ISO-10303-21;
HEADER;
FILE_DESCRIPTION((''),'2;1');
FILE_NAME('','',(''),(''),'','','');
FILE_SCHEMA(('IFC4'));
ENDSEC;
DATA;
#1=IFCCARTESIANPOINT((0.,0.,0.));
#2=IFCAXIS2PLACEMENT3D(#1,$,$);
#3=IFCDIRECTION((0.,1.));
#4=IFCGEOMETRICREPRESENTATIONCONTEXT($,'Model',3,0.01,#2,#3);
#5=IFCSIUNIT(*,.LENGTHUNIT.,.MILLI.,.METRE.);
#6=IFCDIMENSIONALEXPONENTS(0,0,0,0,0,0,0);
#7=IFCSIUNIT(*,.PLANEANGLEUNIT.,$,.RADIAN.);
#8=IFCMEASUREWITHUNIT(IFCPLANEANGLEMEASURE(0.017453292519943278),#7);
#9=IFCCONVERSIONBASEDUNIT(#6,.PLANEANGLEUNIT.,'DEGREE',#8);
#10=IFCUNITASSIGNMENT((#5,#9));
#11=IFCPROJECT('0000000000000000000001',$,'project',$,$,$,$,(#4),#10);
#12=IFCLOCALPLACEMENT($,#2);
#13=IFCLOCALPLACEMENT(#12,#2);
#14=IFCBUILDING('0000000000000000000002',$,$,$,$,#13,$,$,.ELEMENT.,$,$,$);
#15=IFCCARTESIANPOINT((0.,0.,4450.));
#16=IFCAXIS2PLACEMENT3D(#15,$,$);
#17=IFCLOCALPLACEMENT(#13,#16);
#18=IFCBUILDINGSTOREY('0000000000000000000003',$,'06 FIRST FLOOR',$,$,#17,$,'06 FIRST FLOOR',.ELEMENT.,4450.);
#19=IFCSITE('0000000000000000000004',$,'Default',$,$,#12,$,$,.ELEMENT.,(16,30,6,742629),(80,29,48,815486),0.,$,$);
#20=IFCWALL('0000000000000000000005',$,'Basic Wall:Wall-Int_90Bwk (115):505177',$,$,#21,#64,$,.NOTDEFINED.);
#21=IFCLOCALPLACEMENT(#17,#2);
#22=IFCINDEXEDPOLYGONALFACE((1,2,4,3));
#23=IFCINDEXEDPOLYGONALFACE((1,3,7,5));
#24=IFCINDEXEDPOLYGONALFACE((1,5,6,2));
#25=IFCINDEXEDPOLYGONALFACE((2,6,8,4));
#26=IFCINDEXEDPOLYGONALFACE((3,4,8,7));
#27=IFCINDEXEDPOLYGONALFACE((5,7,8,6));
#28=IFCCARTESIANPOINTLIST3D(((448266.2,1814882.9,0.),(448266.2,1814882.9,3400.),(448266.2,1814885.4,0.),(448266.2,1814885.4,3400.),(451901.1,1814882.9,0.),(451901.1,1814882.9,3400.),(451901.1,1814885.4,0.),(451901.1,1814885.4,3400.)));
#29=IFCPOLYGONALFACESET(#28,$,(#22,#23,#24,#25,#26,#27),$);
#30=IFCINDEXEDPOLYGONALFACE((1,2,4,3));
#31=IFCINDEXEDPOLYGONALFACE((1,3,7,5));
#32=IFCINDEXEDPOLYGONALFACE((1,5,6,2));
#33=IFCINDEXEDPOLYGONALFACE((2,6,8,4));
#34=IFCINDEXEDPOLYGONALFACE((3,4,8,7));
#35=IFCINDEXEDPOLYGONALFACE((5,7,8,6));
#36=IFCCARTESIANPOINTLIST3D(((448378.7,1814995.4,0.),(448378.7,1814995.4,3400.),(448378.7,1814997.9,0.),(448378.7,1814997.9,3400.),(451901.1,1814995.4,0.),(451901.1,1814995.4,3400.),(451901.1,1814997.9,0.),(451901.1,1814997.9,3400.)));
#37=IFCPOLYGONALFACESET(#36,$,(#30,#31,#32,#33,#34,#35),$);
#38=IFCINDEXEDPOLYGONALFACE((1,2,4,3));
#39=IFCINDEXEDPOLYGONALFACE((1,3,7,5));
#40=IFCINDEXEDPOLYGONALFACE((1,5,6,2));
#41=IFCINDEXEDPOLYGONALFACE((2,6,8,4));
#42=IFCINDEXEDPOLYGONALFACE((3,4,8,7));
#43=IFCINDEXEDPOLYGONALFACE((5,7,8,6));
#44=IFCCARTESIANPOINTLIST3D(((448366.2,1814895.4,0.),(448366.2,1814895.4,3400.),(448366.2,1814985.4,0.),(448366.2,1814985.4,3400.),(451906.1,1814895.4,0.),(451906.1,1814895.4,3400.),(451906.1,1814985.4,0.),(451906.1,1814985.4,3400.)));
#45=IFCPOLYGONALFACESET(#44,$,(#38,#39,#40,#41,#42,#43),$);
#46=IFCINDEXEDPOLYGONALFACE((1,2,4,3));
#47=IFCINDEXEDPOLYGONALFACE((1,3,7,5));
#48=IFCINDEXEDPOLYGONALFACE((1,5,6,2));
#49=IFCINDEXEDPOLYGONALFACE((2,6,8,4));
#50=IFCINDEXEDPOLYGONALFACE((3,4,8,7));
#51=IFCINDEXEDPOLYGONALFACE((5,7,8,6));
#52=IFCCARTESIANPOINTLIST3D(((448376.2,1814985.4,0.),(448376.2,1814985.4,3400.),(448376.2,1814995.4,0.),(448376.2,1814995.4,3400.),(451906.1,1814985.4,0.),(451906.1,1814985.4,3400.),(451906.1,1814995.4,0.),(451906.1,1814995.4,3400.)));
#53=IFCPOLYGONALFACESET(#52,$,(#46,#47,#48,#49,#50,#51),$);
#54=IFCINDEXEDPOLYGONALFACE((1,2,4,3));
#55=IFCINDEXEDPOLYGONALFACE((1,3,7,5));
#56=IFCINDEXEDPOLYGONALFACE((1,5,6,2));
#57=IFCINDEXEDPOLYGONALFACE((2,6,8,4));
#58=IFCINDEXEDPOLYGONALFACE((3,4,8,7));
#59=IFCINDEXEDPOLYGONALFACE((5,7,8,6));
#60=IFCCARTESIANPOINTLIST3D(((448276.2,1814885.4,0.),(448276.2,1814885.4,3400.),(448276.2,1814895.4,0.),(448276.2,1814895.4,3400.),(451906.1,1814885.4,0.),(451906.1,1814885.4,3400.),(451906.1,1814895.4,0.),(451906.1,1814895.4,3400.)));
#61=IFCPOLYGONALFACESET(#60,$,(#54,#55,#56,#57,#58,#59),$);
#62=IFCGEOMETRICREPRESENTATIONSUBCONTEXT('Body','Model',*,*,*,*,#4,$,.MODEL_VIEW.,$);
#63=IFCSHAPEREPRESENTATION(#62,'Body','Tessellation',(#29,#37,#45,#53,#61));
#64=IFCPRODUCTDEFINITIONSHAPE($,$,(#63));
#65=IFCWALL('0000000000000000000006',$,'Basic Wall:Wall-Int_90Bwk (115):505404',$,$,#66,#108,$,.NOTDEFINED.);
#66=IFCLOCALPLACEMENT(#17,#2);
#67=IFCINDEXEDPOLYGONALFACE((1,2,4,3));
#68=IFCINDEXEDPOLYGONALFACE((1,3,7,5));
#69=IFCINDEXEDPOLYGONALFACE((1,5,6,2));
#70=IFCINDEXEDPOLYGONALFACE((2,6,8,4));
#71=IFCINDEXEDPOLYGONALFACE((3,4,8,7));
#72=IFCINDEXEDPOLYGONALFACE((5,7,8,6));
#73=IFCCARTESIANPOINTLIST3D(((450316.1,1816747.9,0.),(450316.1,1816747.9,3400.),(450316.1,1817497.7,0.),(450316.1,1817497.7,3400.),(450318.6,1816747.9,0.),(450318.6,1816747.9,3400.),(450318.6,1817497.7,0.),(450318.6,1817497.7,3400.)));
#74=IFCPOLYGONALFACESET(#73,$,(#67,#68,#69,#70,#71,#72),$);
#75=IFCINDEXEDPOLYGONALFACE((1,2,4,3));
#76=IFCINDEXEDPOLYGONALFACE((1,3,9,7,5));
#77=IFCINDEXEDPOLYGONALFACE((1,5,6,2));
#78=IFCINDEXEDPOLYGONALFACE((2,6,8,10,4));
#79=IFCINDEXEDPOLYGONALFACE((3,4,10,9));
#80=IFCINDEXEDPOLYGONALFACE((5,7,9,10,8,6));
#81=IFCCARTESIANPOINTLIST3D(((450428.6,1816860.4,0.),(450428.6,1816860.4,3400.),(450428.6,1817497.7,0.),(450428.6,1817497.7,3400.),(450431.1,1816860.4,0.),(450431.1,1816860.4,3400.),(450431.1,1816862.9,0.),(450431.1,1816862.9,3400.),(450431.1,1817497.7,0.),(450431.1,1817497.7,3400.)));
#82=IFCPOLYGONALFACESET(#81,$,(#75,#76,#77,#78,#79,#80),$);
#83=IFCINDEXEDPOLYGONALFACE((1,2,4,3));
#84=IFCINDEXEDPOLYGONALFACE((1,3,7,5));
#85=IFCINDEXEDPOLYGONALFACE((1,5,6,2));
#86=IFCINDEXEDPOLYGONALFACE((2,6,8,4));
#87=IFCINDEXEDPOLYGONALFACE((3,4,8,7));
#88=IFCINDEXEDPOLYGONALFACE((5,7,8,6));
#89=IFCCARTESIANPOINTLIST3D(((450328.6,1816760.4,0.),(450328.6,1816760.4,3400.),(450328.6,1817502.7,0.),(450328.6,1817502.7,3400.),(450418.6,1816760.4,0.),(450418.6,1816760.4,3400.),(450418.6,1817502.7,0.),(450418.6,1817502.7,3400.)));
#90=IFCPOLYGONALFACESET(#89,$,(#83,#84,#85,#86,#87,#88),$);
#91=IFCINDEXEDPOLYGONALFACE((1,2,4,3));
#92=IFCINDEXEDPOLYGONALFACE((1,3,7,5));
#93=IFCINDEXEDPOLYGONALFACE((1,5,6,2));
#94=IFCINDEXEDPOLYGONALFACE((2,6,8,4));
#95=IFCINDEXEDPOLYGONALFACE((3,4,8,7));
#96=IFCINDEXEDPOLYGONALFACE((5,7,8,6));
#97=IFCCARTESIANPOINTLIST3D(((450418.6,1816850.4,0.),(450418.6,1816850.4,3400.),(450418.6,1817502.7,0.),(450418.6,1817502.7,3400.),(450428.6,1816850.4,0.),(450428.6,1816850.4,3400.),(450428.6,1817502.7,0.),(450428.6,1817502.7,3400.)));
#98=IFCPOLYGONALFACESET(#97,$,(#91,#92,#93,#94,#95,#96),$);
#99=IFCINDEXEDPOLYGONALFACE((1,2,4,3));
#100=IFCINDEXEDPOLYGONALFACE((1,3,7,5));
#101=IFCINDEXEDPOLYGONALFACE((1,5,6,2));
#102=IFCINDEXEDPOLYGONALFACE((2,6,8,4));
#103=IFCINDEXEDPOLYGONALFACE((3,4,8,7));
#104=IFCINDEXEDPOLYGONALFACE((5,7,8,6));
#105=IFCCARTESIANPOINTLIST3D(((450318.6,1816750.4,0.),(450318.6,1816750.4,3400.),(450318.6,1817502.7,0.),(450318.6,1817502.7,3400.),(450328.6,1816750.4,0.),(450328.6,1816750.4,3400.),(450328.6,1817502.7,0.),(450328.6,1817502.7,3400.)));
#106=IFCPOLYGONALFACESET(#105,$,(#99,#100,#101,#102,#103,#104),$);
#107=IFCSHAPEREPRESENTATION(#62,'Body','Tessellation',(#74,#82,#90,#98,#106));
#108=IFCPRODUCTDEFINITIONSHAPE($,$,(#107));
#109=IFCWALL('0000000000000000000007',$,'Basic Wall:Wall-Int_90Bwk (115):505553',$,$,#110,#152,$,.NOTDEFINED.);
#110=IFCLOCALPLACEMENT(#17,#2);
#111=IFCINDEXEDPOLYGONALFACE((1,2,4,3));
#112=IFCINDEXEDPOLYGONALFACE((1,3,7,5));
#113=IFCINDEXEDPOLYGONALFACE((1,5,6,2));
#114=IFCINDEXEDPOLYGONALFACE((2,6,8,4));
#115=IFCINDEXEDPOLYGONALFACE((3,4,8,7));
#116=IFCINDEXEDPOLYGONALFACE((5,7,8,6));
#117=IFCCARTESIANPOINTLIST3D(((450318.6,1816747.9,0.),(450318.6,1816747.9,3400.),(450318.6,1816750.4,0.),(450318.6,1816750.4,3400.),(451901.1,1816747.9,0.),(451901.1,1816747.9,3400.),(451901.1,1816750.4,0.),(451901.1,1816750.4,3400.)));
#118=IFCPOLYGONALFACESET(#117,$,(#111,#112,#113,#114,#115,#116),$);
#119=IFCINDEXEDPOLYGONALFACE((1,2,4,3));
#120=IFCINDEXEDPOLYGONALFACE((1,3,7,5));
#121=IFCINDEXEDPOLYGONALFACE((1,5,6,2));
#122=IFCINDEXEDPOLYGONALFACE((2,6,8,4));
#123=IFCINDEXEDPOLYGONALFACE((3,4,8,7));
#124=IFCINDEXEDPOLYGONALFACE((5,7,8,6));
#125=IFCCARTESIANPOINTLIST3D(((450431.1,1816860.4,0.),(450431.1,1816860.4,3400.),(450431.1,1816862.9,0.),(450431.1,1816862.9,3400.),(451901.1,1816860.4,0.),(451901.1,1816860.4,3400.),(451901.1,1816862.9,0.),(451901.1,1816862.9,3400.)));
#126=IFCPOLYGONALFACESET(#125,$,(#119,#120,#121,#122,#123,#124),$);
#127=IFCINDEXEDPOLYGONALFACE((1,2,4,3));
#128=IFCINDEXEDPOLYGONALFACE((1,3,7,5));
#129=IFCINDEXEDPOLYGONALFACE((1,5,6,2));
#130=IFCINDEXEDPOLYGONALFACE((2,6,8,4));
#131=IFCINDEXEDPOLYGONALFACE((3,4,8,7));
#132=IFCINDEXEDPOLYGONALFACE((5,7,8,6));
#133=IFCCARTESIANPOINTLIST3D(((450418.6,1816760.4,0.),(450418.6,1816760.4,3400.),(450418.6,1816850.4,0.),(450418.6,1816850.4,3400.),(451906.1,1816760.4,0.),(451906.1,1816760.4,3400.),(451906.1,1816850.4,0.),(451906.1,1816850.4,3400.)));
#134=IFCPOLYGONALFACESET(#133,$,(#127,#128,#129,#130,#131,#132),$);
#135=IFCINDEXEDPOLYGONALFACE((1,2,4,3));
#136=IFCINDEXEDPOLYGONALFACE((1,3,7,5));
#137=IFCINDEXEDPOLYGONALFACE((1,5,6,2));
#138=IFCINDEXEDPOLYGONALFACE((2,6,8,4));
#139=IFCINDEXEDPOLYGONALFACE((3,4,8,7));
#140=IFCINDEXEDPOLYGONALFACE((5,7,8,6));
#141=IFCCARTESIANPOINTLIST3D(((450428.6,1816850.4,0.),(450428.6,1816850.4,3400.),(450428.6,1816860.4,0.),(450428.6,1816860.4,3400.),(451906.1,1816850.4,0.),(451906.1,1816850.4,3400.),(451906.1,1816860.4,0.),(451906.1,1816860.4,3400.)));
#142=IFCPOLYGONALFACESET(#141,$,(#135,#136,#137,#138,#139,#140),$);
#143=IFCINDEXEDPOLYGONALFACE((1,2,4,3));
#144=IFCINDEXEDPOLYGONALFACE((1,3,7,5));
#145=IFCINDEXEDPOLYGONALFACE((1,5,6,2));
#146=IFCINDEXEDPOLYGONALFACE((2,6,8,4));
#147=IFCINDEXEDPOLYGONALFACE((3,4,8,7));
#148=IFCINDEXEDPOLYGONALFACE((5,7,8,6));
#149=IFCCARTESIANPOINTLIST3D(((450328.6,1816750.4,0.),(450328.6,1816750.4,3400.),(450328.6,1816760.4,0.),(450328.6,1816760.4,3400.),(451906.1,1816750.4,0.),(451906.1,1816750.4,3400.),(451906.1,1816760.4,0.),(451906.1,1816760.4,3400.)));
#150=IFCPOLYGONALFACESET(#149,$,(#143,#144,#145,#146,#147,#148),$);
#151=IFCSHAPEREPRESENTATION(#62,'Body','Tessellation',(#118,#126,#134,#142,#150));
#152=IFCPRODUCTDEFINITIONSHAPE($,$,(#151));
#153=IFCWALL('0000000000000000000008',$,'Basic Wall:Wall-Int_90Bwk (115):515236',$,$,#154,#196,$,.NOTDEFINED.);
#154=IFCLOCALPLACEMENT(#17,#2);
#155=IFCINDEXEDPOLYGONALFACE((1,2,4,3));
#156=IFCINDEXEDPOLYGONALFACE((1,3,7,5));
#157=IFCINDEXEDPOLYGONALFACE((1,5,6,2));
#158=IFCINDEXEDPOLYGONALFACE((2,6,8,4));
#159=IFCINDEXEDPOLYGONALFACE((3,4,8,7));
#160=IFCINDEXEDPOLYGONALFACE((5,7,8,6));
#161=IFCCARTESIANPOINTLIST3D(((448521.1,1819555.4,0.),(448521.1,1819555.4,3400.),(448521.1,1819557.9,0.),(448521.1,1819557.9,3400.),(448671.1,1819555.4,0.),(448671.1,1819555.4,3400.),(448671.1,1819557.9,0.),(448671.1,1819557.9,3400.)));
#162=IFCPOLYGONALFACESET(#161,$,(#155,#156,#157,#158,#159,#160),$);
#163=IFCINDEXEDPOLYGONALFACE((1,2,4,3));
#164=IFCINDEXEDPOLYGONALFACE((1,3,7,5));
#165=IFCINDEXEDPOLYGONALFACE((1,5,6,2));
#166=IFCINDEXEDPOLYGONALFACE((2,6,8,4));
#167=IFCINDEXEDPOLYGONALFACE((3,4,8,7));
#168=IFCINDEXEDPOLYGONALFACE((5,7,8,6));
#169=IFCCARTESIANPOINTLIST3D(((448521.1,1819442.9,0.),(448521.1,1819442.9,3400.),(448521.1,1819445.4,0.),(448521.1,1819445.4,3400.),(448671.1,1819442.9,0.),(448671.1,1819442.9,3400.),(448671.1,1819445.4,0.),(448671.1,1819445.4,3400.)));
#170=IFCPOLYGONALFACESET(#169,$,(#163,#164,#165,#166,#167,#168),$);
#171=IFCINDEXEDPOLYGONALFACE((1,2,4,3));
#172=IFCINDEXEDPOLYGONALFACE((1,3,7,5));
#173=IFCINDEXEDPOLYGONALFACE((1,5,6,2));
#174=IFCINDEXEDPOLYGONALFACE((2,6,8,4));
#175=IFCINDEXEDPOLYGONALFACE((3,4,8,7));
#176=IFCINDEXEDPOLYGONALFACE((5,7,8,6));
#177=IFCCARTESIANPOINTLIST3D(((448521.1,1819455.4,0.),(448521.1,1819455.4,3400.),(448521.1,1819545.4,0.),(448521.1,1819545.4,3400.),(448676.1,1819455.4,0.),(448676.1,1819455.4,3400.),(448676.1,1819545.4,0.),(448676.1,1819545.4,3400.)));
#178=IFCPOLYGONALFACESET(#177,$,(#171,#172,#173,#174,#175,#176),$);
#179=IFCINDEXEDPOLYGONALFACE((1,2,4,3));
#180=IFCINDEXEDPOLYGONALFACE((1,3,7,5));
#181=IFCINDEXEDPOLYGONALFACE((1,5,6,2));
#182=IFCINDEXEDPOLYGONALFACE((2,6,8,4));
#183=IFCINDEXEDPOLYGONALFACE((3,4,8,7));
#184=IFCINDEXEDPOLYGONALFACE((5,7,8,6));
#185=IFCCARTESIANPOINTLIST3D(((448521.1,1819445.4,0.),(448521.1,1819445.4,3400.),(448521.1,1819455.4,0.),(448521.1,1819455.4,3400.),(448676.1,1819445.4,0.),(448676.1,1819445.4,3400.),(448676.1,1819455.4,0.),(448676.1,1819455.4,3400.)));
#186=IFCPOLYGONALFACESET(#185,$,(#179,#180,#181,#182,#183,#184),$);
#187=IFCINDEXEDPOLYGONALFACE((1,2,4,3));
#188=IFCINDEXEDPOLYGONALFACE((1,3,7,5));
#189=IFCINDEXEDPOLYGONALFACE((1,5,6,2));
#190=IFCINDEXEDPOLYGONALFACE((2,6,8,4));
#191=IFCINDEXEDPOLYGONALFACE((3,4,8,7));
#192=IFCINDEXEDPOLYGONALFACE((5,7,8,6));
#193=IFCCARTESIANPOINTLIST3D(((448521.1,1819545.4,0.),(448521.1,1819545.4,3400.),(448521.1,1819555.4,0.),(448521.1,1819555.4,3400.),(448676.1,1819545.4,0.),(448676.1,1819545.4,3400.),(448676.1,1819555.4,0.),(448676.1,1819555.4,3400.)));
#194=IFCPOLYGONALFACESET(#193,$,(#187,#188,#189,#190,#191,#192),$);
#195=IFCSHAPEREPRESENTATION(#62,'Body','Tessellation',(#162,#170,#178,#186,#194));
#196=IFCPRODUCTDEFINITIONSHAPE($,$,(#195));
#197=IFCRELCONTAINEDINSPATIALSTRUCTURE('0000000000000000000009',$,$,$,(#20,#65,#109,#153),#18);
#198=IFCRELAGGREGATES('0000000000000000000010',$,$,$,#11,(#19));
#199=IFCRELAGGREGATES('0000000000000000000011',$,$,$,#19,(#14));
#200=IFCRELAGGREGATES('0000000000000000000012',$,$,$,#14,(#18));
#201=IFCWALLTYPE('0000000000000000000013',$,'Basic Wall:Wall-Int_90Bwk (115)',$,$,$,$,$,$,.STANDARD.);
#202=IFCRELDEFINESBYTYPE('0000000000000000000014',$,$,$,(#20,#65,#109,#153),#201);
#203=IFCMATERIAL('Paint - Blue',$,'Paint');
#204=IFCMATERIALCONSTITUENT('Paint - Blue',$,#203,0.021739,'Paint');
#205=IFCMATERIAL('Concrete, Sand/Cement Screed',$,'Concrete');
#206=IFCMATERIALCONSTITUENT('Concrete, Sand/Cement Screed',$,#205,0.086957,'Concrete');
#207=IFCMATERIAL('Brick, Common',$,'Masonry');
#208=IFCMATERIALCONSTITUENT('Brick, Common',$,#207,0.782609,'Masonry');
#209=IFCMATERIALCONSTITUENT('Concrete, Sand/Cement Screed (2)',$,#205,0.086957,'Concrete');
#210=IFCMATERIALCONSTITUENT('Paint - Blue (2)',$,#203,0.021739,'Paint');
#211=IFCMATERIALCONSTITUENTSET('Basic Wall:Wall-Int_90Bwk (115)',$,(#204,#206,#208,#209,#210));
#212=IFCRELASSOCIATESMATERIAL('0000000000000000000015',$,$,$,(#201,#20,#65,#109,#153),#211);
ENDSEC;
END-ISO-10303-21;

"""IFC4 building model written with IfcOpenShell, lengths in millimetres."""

from ifc_helpers import new_model, entity, si_unit, converted_unit, direction, frame, origin, place, context, subcontext, project, spatial, indexed_curve, outline, extrude, material, constituent, constituent_set, type_object, element, save


model = new_model("IFC4")

# Units and contexts
model_context = context("Model", 3, precision=0.01, world=origin(), true_north=direction((0.0, 1.0)))
body_context = subcontext(model_context, "Body", "Model", "MODEL_VIEW")
ifc_project = project(units=[si_unit("LENGTHUNIT", "METRE", prefix="MILLI"), converted_unit("PLANEANGLEUNIT", "DEGREE", entity("IfcPlaneAngleMeasure", 0.017453292519943278), si_unit("PLANEANGLEUNIT", "RADIAN"), dimensions=[0, 0, 0, 0, 0, 0, 0])], contexts=[model_context])

# Site, building, storey
site_placement = place(None, origin())
site = spatial("IfcSite", under=ifc_project, at=site_placement, Name="Default", CompositionType="ELEMENT", RefLatitude=(16, 30, 6, 742629), RefLongitude=(80, 29, 48, 815486), RefElevation=0.0)
building_placement = place(site_placement, origin())
building = spatial("IfcBuilding", under=site, at=building_placement, CompositionType="ELEMENT")
storey_placement = place(building_placement, frame((0.0, 0.0, 4450.0)))
storey = spatial("IfcBuildingStorey", under=building, at=storey_placement, Name="06 FIRST FLOOR", LongName="06 FIRST FLOOR", CompositionType="ELEMENT", Elevation=4450.0)

# Shared definitions
ifc_material_1 = material(Name="Paint - Blue", Category="Paint")
ifc_constituent_1 = constituent(ifc_material_1, Name="Paint - Blue", Category="Paint", fraction=0.021739)
ifc_material_2 = material(Name="Concrete, Sand/Cement Screed", Category="Concrete")
ifc_constituent_2 = constituent(ifc_material_2, Name="Concrete, Sand/Cement Screed", Category="Concrete", fraction=0.086957)
ifc_material_3 = material(Name="Brick, Common", Category="Masonry")
ifc_constituent_3 = constituent(ifc_material_3, Name="Brick, Common", Category="Masonry", fraction=0.782609)
ifc_constituent_4 = constituent(ifc_material_2, Name="Concrete, Sand/Cement Screed (2)", Category="Concrete", fraction=0.086957)
ifc_constituent_5 = constituent(ifc_material_1, Name="Paint - Blue (2)", Category="Paint", fraction=0.021739)
ifc_constituent_set_1 = constituent_set(constituents=[ifc_constituent_1, ifc_constituent_2, ifc_constituent_3, ifc_constituent_4, ifc_constituent_5], Name="Basic Wall:Wall-Int_90Bwk (115)")
wall_type_1 = type_object("IfcWallType", Name="Basic Wall:Wall-Int_90Bwk (115)", PredefinedType="STANDARD", material=ifc_constituent_set_1)

# Walls
wall_1_placement = place(storey_placement, frame((448378.7, 1814940.4, 0.0)))
element("IfcWall", 1, at=wall_1_placement, inside=storey, type_object=wall_type_1, material=ifc_constituent_set_1, Name="Basic Wall:Wall-Int_90Bwk (115):505177", PredefinedType="NOTDEFINED", context=body_context, shape_type="SweptSolid", body=[
    extrude(outline(indexed_curve([(-1.2, -1817.5), (1.3, -1817.5), (1.3, 1817.5), (-1.2, 1817.5), (-1.2, -1817.5)], self_intersect=False)), frame((1705.0, -56.3, 0.0), z_axis=(0.0, 0.0, 1.0), x_axis=(0.0, 1.0, 0.0)), (0.0, 0.0, 1.0), 3400.0),
    extrude(outline(indexed_curve([(-1.2, -1761.2), (1.3, -1761.2), (1.3, 1761.2), (-1.2, 1761.2), (-1.2, -1761.2)], self_intersect=False)), frame((1761.2, 56.3, 0.0), z_axis=(0.0, 0.0, 1.0), x_axis=(0.0, -1.0, 0.0)), (0.0, 0.0, 1.0), 3400.0),
    extrude(outline(indexed_curve([(-1770.0, -45.0), (1770.0, -45.0), (1770.0, 45.0), (-1770.0, 45.0), (-1770.0, -45.0)], self_intersect=False)), frame((1757.5, 0.0, 0.0)), (0.0, 0.0, 1.0), 3400.0),
    extrude(outline(indexed_curve([(-1765.0, -5.0), (1765.0, -5.0), (1765.0, 5.0), (-1765.0, 5.0), (-1765.0, -5.0)], self_intersect=False)), frame((1762.5, 50.0, 0.0)), (0.0, 0.0, 1.0), 3400.0),
    extrude(outline(indexed_curve([(-1815.0, -5.0), (1815.0, -5.0), (1815.0, 5.0), (-1815.0, 5.0), (-1815.0, -5.0)], self_intersect=False)), frame((1712.5, -50.0, 0.0)), (0.0, 0.0, 1.0), 3400.0),
])
wall_2_placement = place(storey_placement, frame((450373.6, 1817497.7, 0.0), z_axis=(0.0, 0.0, 1.0), x_axis=(0.0, -1.0, 0.0)))
element("IfcWall", 2, at=wall_2_placement, inside=storey, type_object=wall_type_1, material=ifc_constituent_set_1, Name="Basic Wall:Wall-Int_90Bwk (115):505404", PredefinedType="NOTDEFINED", context=body_context, shape_type="SweptSolid", body=[
    extrude(outline(indexed_curve([(-1.3, -374.9), (1.2, -374.9), (1.2, 374.9), (-1.3, 374.9), (-1.3, -374.9)], self_intersect=False)), frame((374.9, -56.2, 0.0), z_axis=(0.0, 0.0, 1.0), x_axis=(0.0, 1.0, 0.0)), (0.0, 0.0, 1.0), 3400.0),
    extrude(outline(indexed_curve([(-252.9, -1.0), (381.9, -1.0), (381.9, 1.5), (-255.4, 1.5), (-255.4, -1.0), (-252.9, -1.0)], self_intersect=False)), frame((381.9, 56.5, 0.0), z_axis=(0.0, 0.0, 1.0), x_axis=(-1.0, 0.0, 0.0)), (0.0, 0.0, 1.0), 3400.0),
    extrude(outline(indexed_curve([(-371.2, -45.0), (371.2, -45.0), (371.2, 45.0), (-371.2, 45.0), (-371.2, -45.0)], self_intersect=False)), frame((366.2, 0.0, 0.0)), (0.0, 0.0, 1.0), 3400.0),
    extrude(outline(indexed_curve([(-326.2, -5.0), (326.2, -5.0), (326.2, 5.0), (-326.2, 5.0), (-326.2, -5.0)], self_intersect=False)), frame((321.2, 50.0, 0.0)), (0.0, 0.0, 1.0), 3400.0),
    extrude(outline(indexed_curve([(-376.2, -5.0), (376.2, -5.0), (376.2, 5.0), (-376.2, 5.0), (-376.2, -5.0)], self_intersect=False)), frame((371.2, -50.0, 0.0)), (0.0, 0.0, 1.0), 3400.0),
])
wall_3_placement = place(storey_placement, frame((450431.1, 1816805.4, 0.0)))
element("IfcWall", 3, at=wall_3_placement, inside=storey, type_object=wall_type_1, material=ifc_constituent_set_1, Name="Basic Wall:Wall-Int_90Bwk (115):505553", PredefinedType="NOTDEFINED", context=body_context, shape_type="SweptSolid", body=[
    extrude(outline(indexed_curve([(-1.2, -791.3), (1.3, -791.3), (1.3, 791.3), (-1.2, 791.3), (-1.2, -791.3)], self_intersect=False)), frame((678.8, -56.3, 0.0), z_axis=(0.0, 0.0, 1.0), x_axis=(0.0, 1.0, 0.0)), (0.0, 0.0, 1.0), 3400.0),
    extrude(outline(indexed_curve([(-1.2, -735.0), (1.3, -735.0), (1.3, 735.0), (-1.2, 735.0), (-1.2, -735.0)], self_intersect=False)), frame((735.0, 56.3, 0.0), z_axis=(0.0, 0.0, 1.0), x_axis=(0.0, -1.0, 0.0)), (0.0, 0.0, 1.0), 3400.0),
    extrude(outline(indexed_curve([(-743.8, -45.0), (743.8, -45.0), (743.8, 45.0), (-743.8, 45.0), (-743.8, -45.0)], self_intersect=False)), frame((731.3, 0.0, 0.0)), (0.0, 0.0, 1.0), 3400.0),
    extrude(outline(indexed_curve([(-738.8, -5.0), (738.8, -5.0), (738.8, 5.0), (-738.8, 5.0), (-738.8, -5.0)], self_intersect=False)), frame((736.3, 50.0, 0.0)), (0.0, 0.0, 1.0), 3400.0),
    extrude(outline(indexed_curve([(-788.8, -5.0), (788.8, -5.0), (788.8, 5.0), (-788.8, 5.0), (-788.8, -5.0)], self_intersect=False)), frame((686.3, -50.0, 0.0)), (0.0, 0.0, 1.0), 3400.0),
])
wall_4_placement = place(storey_placement, frame((448671.1, 1819500.4, 0.0), z_axis=(0.0, 0.0, 1.0), x_axis=(-1.0, 0.0, 0.0)))
element("IfcWall", 4, at=wall_4_placement, inside=storey, type_object=wall_type_1, material=ifc_constituent_set_1, Name="Basic Wall:Wall-Int_90Bwk (115):515236", PredefinedType="NOTDEFINED", context=body_context, shape_type="SweptSolid", body=[
    extrude(outline(indexed_curve([(-1.2, -75.0), (1.3, -75.0), (1.3, 75.0), (-1.2, 75.0), (-1.2, -75.0)], self_intersect=False)), frame((75.0, -56.3, 0.0), z_axis=(0.0, 0.0, 1.0), x_axis=(0.0, 1.0, 0.0)), (0.0, 0.0, 1.0), 3400.0),
    extrude(outline(indexed_curve([(-1.2, -75.0), (1.3, -75.0), (1.3, 75.0), (-1.2, 75.0), (-1.2, -75.0)], self_intersect=False)), frame((75.0, 56.3, 0.0), z_axis=(0.0, 0.0, 1.0), x_axis=(0.0, -1.0, 0.0)), (0.0, 0.0, 1.0), 3400.0),
    extrude(outline(indexed_curve([(-77.5, -45.0), (77.5, -45.0), (77.5, 45.0), (-77.5, 45.0), (-77.5, -45.0)], self_intersect=False)), frame((72.5, 0.0, 0.0)), (0.0, 0.0, 1.0), 3400.0),
    extrude(outline(indexed_curve([(-77.5, -5.0), (77.5, -5.0), (77.5, 5.0), (-77.5, 5.0), (-77.5, -5.0)], self_intersect=False)), frame((72.5, 50.0, 0.0)), (0.0, 0.0, 1.0), 3400.0),
    extrude(outline(indexed_curve([(-77.5, -5.0), (77.5, -5.0), (77.5, 5.0), (-77.5, 5.0), (-77.5, -5.0)], self_intersect=False)), frame((72.5, -50.0, 0.0)), (0.0, 0.0, 1.0), 3400.0),
])

save(model, "model.ifc")
